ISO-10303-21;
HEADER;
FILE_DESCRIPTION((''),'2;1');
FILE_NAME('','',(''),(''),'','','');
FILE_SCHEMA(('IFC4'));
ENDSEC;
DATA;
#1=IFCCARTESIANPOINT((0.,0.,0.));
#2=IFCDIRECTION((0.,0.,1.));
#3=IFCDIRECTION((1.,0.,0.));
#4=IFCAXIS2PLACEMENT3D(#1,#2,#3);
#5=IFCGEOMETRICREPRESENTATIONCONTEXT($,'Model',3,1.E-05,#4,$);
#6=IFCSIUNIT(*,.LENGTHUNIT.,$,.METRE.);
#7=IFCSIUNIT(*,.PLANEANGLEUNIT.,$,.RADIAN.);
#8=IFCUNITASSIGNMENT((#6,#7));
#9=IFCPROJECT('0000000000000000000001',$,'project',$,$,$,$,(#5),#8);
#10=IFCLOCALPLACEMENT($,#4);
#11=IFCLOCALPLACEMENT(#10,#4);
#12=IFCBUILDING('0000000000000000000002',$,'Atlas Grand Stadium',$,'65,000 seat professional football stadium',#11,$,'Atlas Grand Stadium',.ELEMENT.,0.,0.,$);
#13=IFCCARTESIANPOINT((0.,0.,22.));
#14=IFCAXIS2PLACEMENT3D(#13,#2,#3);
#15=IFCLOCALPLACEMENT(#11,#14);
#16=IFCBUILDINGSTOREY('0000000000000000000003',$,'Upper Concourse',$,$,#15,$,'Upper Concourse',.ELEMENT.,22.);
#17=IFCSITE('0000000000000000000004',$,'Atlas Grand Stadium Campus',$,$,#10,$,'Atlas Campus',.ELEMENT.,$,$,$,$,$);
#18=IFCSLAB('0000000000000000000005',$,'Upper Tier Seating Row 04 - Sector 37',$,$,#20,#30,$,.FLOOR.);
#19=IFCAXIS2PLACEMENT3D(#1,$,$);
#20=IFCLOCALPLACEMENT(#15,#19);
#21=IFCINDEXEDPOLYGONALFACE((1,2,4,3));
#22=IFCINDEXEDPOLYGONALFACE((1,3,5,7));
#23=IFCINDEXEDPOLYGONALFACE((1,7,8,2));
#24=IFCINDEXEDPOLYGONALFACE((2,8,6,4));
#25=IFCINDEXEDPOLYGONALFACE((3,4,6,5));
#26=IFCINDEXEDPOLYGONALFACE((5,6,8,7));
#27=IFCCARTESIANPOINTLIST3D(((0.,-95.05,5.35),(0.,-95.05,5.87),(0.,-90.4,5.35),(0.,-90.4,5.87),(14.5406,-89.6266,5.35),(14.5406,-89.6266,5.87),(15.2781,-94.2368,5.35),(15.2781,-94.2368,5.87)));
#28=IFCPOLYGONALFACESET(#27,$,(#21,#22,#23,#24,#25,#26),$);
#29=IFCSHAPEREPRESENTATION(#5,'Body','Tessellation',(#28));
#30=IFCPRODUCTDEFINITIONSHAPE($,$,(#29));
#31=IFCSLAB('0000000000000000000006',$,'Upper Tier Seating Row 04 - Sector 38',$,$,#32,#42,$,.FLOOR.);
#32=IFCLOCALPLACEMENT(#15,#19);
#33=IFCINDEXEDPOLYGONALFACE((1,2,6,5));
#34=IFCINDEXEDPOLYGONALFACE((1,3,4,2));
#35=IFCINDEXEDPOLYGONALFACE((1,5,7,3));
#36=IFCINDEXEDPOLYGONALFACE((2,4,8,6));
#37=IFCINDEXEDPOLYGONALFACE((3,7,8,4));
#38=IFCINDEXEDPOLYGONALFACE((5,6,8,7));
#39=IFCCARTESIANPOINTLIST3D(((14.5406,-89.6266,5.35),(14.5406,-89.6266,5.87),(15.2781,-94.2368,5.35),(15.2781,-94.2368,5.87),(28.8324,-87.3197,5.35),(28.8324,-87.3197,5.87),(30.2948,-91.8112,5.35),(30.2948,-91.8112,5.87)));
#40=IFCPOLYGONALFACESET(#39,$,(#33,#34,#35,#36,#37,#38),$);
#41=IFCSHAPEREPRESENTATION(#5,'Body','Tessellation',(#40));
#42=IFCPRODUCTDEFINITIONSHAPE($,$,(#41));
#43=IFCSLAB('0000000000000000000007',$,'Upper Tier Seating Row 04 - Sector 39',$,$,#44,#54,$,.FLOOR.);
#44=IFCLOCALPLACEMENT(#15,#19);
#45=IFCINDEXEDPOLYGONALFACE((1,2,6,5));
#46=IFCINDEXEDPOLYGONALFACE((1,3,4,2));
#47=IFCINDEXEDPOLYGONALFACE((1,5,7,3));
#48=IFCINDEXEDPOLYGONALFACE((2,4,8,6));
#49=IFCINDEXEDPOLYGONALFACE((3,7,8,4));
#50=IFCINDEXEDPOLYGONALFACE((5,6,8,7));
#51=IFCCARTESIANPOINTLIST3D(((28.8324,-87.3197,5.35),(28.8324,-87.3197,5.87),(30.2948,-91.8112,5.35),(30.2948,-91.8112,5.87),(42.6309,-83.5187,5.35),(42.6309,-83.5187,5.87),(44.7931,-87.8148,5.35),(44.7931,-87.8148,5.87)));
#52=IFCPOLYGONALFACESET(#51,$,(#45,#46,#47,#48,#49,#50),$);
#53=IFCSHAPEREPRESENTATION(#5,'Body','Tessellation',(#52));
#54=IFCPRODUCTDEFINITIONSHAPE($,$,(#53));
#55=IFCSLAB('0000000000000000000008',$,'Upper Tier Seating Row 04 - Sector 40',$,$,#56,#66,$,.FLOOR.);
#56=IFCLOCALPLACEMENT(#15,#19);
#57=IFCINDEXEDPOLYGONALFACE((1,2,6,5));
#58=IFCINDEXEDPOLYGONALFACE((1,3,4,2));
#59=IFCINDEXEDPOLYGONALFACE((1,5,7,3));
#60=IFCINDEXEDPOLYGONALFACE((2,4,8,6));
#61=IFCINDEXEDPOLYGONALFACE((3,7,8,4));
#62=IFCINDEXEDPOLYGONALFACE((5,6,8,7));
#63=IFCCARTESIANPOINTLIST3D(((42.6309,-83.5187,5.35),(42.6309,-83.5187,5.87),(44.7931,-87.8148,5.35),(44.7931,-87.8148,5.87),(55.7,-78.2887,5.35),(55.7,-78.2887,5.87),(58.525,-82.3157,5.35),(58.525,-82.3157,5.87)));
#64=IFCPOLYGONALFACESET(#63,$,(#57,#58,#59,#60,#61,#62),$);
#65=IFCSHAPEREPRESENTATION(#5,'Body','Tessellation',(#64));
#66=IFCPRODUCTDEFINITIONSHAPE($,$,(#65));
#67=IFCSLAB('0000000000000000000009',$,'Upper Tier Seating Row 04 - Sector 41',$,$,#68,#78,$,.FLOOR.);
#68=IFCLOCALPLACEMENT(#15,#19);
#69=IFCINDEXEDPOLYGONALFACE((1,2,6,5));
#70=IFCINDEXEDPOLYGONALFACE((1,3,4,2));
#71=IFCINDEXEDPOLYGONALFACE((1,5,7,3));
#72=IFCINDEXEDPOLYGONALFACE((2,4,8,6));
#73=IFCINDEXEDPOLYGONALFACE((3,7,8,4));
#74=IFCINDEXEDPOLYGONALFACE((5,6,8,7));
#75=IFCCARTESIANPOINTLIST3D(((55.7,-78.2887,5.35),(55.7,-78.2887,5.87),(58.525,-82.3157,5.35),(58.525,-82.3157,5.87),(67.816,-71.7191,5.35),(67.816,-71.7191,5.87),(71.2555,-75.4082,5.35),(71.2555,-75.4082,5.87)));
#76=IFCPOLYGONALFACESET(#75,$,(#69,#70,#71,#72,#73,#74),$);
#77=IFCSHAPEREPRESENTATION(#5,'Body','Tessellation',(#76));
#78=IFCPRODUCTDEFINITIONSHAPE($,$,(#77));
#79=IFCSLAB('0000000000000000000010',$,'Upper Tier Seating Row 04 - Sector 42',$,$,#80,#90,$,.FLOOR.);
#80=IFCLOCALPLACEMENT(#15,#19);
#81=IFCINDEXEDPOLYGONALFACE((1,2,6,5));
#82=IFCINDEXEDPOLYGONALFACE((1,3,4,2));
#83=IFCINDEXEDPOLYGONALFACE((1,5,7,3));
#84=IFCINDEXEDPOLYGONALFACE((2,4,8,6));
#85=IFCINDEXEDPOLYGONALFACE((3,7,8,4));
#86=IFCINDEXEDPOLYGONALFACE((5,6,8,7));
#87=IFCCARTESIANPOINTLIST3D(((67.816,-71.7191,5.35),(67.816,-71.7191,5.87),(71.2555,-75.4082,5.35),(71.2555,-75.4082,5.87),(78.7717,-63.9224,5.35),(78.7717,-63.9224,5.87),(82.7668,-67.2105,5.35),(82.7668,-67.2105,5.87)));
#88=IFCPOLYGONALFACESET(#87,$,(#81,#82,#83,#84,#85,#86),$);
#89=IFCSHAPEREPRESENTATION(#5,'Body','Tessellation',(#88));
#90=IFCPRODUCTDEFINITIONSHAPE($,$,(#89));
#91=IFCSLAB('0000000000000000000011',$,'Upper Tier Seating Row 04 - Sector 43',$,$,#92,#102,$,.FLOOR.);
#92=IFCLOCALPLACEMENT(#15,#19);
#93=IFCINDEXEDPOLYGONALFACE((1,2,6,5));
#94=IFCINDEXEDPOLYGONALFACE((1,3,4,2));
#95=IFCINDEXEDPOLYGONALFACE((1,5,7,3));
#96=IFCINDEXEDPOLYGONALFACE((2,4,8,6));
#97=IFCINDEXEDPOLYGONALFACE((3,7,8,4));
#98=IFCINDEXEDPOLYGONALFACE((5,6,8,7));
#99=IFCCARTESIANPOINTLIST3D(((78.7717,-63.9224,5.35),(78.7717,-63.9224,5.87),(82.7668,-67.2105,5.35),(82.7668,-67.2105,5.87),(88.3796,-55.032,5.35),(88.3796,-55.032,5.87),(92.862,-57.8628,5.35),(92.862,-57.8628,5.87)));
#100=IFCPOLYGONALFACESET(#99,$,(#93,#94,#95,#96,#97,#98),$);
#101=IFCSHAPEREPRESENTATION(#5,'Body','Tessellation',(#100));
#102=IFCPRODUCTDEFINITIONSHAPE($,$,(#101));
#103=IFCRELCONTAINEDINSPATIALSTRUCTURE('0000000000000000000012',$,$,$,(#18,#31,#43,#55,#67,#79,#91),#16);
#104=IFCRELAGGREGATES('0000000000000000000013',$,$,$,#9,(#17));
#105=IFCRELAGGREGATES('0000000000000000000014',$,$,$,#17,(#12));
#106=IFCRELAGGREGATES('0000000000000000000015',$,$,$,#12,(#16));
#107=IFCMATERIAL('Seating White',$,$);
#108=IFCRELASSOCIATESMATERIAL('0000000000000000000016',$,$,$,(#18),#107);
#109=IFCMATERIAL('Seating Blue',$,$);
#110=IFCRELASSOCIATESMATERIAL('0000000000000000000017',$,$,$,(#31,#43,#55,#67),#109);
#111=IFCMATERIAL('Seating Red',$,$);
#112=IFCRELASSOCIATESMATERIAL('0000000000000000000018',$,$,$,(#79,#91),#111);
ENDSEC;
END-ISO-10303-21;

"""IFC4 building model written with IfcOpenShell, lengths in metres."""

from ifc_helpers import new_model, si_unit, frame, origin_with_axes, place, context, project, spatial, polyline, outline, extrude, material, element, save


model = new_model("IFC4")

# Units and contexts
model_context = context("Model", 3, precision=1e-05, world=origin_with_axes())
ifc_project = project(units=[si_unit("LENGTHUNIT", "METRE"), si_unit("PLANEANGLEUNIT", "RADIAN")], contexts=[model_context])

# Site, building, storey
site_placement = place(None, origin_with_axes())
site = spatial("IfcSite", under=ifc_project, at=site_placement, Name="Atlas Grand Stadium Campus", LongName="Atlas Campus", CompositionType="ELEMENT")
building_placement = place(site_placement, origin_with_axes())
building = spatial("IfcBuilding", under=site, at=building_placement, Name="Atlas Grand Stadium", ObjectType="65,000 seat professional football stadium", LongName="Atlas Grand Stadium", CompositionType="ELEMENT", ElevationOfRefHeight=0.0, ElevationOfTerrain=0.0)
storey_placement = place(building_placement, frame((0.0, 0.0, 22.0), z_axis=(0.0, 0.0, 1.0), x_axis=(1.0, 0.0, 0.0)))
storey = spatial("IfcBuildingStorey", under=building, at=storey_placement, Name="Upper Concourse", LongName="Upper Concourse", CompositionType="ELEMENT", Elevation=22.0)

# Slabs
ifc_material_1 = material(Name="Seating Blue")
ifc_material_2 = material(Name="Seating Red")
ifc_material_3 = material(Name="Seating White")
slab_1_placement = place(storey_placement, frame((0.0, 0.0, 5.35), z_axis=(0.0, 0.0, 1.0), x_axis=(1.0, 0.0, 0.0)))
element("IfcSlab", 1, at=slab_1_placement, inside=storey, material=ifc_material_3, Name="Upper Tier Seating Row 04 - Sector 37", PredefinedType="FLOOR", context=model_context, shape_type="SweptSolid", body=[
    extrude(outline(polyline([(0.0, -95.05), (15.2781, -94.2368), (14.5406, -89.6266), (0.0, -90.4), (0.0, -95.05)])), origin_with_axes(), (0.0, 0.0, 1.0), 0.52),
])
slab_2_placement = place(storey_placement, frame((0.0, 0.0, 5.35), z_axis=(0.0, 0.0, 1.0), x_axis=(1.0, 0.0, 0.0)))
element("IfcSlab", 2, at=slab_2_placement, inside=storey, material=ifc_material_1, Name="Upper Tier Seating Row 04 - Sector 38", PredefinedType="FLOOR", context=model_context, shape_type="SweptSolid", body=[
    extrude(outline(polyline([(15.2781, -94.2368), (30.2948, -91.8113), (28.8324, -87.3197), (14.5406, -89.6266), (15.2781, -94.2368)])), origin_with_axes(), (0.0, 0.0, 1.0), 0.52),
])
slab_3_placement = place(storey_placement, frame((0.0, 0.0, 5.35), z_axis=(0.0, 0.0, 1.0), x_axis=(1.0, 0.0, 0.0)))
element("IfcSlab", 3, at=slab_3_placement, inside=storey, material=ifc_material_1, Name="Upper Tier Seating Row 04 - Sector 39", PredefinedType="FLOOR", context=model_context, shape_type="SweptSolid", body=[
    extrude(outline(polyline([(30.2948, -91.8113), (44.7931, -87.8148), (42.6309, -83.5187), (28.8324, -87.3197), (30.2948, -91.8113)])), origin_with_axes(), (0.0, 0.0, 1.0), 0.52),
])
slab_4_placement = place(storey_placement, frame((0.0, 0.0, 5.35), z_axis=(0.0, 0.0, 1.0), x_axis=(1.0, 0.0, 0.0)))
element("IfcSlab", 4, at=slab_4_placement, inside=storey, material=ifc_material_1, Name="Upper Tier Seating Row 04 - Sector 40", PredefinedType="FLOOR", context=model_context, shape_type="SweptSolid", body=[
    extrude(outline(polyline([(44.7931, -87.8148), (58.525, -82.3157), (55.7, -78.2887), (42.6309, -83.5187), (44.7931, -87.8148)])), origin_with_axes(), (0.0, 0.0, 1.0), 0.52),
])
slab_5_placement = place(storey_placement, frame((0.0, 0.0, 5.35), z_axis=(0.0, 0.0, 1.0), x_axis=(1.0, 0.0, 0.0)))
element("IfcSlab", 5, at=slab_5_placement, inside=storey, material=ifc_material_1, Name="Upper Tier Seating Row 04 - Sector 41", PredefinedType="FLOOR", context=model_context, shape_type="SweptSolid", body=[
    extrude(outline(polyline([(58.525, -82.3157), (71.2555, -75.4082), (67.816, -71.7191), (55.7, -78.2887), (58.525, -82.3157)])), origin_with_axes(), (0.0, 0.0, 1.0), 0.52),
])
slab_6_placement = place(storey_placement, frame((0.0, 0.0, 5.35), z_axis=(0.0, 0.0, 1.0), x_axis=(1.0, 0.0, 0.0)))
element("IfcSlab", 6, at=slab_6_placement, inside=storey, material=ifc_material_2, Name="Upper Tier Seating Row 04 - Sector 42", PredefinedType="FLOOR", context=model_context, shape_type="SweptSolid", body=[
    extrude(outline(polyline([(71.2555, -75.4082), (82.7669, -67.2105), (78.7717, -63.9224), (67.816, -71.7191), (71.2555, -75.4082)])), origin_with_axes(), (0.0, 0.0, 1.0), 0.52),
])
slab_7_placement = place(storey_placement, frame((0.0, 0.0, 5.35), z_axis=(0.0, 0.0, 1.0), x_axis=(1.0, 0.0, 0.0)))
element("IfcSlab", 7, at=slab_7_placement, inside=storey, material=ifc_material_2, Name="Upper Tier Seating Row 04 - Sector 43", PredefinedType="FLOOR", context=model_context, shape_type="SweptSolid", body=[
    extrude(outline(polyline([(82.7669, -67.2105), (92.862, -57.8628), (88.3796, -55.032), (78.7717, -63.9224), (82.7669, -67.2105)])), origin_with_axes(), (0.0, 0.0, 1.0), 0.52),
])

save(model, "model.ifc")
